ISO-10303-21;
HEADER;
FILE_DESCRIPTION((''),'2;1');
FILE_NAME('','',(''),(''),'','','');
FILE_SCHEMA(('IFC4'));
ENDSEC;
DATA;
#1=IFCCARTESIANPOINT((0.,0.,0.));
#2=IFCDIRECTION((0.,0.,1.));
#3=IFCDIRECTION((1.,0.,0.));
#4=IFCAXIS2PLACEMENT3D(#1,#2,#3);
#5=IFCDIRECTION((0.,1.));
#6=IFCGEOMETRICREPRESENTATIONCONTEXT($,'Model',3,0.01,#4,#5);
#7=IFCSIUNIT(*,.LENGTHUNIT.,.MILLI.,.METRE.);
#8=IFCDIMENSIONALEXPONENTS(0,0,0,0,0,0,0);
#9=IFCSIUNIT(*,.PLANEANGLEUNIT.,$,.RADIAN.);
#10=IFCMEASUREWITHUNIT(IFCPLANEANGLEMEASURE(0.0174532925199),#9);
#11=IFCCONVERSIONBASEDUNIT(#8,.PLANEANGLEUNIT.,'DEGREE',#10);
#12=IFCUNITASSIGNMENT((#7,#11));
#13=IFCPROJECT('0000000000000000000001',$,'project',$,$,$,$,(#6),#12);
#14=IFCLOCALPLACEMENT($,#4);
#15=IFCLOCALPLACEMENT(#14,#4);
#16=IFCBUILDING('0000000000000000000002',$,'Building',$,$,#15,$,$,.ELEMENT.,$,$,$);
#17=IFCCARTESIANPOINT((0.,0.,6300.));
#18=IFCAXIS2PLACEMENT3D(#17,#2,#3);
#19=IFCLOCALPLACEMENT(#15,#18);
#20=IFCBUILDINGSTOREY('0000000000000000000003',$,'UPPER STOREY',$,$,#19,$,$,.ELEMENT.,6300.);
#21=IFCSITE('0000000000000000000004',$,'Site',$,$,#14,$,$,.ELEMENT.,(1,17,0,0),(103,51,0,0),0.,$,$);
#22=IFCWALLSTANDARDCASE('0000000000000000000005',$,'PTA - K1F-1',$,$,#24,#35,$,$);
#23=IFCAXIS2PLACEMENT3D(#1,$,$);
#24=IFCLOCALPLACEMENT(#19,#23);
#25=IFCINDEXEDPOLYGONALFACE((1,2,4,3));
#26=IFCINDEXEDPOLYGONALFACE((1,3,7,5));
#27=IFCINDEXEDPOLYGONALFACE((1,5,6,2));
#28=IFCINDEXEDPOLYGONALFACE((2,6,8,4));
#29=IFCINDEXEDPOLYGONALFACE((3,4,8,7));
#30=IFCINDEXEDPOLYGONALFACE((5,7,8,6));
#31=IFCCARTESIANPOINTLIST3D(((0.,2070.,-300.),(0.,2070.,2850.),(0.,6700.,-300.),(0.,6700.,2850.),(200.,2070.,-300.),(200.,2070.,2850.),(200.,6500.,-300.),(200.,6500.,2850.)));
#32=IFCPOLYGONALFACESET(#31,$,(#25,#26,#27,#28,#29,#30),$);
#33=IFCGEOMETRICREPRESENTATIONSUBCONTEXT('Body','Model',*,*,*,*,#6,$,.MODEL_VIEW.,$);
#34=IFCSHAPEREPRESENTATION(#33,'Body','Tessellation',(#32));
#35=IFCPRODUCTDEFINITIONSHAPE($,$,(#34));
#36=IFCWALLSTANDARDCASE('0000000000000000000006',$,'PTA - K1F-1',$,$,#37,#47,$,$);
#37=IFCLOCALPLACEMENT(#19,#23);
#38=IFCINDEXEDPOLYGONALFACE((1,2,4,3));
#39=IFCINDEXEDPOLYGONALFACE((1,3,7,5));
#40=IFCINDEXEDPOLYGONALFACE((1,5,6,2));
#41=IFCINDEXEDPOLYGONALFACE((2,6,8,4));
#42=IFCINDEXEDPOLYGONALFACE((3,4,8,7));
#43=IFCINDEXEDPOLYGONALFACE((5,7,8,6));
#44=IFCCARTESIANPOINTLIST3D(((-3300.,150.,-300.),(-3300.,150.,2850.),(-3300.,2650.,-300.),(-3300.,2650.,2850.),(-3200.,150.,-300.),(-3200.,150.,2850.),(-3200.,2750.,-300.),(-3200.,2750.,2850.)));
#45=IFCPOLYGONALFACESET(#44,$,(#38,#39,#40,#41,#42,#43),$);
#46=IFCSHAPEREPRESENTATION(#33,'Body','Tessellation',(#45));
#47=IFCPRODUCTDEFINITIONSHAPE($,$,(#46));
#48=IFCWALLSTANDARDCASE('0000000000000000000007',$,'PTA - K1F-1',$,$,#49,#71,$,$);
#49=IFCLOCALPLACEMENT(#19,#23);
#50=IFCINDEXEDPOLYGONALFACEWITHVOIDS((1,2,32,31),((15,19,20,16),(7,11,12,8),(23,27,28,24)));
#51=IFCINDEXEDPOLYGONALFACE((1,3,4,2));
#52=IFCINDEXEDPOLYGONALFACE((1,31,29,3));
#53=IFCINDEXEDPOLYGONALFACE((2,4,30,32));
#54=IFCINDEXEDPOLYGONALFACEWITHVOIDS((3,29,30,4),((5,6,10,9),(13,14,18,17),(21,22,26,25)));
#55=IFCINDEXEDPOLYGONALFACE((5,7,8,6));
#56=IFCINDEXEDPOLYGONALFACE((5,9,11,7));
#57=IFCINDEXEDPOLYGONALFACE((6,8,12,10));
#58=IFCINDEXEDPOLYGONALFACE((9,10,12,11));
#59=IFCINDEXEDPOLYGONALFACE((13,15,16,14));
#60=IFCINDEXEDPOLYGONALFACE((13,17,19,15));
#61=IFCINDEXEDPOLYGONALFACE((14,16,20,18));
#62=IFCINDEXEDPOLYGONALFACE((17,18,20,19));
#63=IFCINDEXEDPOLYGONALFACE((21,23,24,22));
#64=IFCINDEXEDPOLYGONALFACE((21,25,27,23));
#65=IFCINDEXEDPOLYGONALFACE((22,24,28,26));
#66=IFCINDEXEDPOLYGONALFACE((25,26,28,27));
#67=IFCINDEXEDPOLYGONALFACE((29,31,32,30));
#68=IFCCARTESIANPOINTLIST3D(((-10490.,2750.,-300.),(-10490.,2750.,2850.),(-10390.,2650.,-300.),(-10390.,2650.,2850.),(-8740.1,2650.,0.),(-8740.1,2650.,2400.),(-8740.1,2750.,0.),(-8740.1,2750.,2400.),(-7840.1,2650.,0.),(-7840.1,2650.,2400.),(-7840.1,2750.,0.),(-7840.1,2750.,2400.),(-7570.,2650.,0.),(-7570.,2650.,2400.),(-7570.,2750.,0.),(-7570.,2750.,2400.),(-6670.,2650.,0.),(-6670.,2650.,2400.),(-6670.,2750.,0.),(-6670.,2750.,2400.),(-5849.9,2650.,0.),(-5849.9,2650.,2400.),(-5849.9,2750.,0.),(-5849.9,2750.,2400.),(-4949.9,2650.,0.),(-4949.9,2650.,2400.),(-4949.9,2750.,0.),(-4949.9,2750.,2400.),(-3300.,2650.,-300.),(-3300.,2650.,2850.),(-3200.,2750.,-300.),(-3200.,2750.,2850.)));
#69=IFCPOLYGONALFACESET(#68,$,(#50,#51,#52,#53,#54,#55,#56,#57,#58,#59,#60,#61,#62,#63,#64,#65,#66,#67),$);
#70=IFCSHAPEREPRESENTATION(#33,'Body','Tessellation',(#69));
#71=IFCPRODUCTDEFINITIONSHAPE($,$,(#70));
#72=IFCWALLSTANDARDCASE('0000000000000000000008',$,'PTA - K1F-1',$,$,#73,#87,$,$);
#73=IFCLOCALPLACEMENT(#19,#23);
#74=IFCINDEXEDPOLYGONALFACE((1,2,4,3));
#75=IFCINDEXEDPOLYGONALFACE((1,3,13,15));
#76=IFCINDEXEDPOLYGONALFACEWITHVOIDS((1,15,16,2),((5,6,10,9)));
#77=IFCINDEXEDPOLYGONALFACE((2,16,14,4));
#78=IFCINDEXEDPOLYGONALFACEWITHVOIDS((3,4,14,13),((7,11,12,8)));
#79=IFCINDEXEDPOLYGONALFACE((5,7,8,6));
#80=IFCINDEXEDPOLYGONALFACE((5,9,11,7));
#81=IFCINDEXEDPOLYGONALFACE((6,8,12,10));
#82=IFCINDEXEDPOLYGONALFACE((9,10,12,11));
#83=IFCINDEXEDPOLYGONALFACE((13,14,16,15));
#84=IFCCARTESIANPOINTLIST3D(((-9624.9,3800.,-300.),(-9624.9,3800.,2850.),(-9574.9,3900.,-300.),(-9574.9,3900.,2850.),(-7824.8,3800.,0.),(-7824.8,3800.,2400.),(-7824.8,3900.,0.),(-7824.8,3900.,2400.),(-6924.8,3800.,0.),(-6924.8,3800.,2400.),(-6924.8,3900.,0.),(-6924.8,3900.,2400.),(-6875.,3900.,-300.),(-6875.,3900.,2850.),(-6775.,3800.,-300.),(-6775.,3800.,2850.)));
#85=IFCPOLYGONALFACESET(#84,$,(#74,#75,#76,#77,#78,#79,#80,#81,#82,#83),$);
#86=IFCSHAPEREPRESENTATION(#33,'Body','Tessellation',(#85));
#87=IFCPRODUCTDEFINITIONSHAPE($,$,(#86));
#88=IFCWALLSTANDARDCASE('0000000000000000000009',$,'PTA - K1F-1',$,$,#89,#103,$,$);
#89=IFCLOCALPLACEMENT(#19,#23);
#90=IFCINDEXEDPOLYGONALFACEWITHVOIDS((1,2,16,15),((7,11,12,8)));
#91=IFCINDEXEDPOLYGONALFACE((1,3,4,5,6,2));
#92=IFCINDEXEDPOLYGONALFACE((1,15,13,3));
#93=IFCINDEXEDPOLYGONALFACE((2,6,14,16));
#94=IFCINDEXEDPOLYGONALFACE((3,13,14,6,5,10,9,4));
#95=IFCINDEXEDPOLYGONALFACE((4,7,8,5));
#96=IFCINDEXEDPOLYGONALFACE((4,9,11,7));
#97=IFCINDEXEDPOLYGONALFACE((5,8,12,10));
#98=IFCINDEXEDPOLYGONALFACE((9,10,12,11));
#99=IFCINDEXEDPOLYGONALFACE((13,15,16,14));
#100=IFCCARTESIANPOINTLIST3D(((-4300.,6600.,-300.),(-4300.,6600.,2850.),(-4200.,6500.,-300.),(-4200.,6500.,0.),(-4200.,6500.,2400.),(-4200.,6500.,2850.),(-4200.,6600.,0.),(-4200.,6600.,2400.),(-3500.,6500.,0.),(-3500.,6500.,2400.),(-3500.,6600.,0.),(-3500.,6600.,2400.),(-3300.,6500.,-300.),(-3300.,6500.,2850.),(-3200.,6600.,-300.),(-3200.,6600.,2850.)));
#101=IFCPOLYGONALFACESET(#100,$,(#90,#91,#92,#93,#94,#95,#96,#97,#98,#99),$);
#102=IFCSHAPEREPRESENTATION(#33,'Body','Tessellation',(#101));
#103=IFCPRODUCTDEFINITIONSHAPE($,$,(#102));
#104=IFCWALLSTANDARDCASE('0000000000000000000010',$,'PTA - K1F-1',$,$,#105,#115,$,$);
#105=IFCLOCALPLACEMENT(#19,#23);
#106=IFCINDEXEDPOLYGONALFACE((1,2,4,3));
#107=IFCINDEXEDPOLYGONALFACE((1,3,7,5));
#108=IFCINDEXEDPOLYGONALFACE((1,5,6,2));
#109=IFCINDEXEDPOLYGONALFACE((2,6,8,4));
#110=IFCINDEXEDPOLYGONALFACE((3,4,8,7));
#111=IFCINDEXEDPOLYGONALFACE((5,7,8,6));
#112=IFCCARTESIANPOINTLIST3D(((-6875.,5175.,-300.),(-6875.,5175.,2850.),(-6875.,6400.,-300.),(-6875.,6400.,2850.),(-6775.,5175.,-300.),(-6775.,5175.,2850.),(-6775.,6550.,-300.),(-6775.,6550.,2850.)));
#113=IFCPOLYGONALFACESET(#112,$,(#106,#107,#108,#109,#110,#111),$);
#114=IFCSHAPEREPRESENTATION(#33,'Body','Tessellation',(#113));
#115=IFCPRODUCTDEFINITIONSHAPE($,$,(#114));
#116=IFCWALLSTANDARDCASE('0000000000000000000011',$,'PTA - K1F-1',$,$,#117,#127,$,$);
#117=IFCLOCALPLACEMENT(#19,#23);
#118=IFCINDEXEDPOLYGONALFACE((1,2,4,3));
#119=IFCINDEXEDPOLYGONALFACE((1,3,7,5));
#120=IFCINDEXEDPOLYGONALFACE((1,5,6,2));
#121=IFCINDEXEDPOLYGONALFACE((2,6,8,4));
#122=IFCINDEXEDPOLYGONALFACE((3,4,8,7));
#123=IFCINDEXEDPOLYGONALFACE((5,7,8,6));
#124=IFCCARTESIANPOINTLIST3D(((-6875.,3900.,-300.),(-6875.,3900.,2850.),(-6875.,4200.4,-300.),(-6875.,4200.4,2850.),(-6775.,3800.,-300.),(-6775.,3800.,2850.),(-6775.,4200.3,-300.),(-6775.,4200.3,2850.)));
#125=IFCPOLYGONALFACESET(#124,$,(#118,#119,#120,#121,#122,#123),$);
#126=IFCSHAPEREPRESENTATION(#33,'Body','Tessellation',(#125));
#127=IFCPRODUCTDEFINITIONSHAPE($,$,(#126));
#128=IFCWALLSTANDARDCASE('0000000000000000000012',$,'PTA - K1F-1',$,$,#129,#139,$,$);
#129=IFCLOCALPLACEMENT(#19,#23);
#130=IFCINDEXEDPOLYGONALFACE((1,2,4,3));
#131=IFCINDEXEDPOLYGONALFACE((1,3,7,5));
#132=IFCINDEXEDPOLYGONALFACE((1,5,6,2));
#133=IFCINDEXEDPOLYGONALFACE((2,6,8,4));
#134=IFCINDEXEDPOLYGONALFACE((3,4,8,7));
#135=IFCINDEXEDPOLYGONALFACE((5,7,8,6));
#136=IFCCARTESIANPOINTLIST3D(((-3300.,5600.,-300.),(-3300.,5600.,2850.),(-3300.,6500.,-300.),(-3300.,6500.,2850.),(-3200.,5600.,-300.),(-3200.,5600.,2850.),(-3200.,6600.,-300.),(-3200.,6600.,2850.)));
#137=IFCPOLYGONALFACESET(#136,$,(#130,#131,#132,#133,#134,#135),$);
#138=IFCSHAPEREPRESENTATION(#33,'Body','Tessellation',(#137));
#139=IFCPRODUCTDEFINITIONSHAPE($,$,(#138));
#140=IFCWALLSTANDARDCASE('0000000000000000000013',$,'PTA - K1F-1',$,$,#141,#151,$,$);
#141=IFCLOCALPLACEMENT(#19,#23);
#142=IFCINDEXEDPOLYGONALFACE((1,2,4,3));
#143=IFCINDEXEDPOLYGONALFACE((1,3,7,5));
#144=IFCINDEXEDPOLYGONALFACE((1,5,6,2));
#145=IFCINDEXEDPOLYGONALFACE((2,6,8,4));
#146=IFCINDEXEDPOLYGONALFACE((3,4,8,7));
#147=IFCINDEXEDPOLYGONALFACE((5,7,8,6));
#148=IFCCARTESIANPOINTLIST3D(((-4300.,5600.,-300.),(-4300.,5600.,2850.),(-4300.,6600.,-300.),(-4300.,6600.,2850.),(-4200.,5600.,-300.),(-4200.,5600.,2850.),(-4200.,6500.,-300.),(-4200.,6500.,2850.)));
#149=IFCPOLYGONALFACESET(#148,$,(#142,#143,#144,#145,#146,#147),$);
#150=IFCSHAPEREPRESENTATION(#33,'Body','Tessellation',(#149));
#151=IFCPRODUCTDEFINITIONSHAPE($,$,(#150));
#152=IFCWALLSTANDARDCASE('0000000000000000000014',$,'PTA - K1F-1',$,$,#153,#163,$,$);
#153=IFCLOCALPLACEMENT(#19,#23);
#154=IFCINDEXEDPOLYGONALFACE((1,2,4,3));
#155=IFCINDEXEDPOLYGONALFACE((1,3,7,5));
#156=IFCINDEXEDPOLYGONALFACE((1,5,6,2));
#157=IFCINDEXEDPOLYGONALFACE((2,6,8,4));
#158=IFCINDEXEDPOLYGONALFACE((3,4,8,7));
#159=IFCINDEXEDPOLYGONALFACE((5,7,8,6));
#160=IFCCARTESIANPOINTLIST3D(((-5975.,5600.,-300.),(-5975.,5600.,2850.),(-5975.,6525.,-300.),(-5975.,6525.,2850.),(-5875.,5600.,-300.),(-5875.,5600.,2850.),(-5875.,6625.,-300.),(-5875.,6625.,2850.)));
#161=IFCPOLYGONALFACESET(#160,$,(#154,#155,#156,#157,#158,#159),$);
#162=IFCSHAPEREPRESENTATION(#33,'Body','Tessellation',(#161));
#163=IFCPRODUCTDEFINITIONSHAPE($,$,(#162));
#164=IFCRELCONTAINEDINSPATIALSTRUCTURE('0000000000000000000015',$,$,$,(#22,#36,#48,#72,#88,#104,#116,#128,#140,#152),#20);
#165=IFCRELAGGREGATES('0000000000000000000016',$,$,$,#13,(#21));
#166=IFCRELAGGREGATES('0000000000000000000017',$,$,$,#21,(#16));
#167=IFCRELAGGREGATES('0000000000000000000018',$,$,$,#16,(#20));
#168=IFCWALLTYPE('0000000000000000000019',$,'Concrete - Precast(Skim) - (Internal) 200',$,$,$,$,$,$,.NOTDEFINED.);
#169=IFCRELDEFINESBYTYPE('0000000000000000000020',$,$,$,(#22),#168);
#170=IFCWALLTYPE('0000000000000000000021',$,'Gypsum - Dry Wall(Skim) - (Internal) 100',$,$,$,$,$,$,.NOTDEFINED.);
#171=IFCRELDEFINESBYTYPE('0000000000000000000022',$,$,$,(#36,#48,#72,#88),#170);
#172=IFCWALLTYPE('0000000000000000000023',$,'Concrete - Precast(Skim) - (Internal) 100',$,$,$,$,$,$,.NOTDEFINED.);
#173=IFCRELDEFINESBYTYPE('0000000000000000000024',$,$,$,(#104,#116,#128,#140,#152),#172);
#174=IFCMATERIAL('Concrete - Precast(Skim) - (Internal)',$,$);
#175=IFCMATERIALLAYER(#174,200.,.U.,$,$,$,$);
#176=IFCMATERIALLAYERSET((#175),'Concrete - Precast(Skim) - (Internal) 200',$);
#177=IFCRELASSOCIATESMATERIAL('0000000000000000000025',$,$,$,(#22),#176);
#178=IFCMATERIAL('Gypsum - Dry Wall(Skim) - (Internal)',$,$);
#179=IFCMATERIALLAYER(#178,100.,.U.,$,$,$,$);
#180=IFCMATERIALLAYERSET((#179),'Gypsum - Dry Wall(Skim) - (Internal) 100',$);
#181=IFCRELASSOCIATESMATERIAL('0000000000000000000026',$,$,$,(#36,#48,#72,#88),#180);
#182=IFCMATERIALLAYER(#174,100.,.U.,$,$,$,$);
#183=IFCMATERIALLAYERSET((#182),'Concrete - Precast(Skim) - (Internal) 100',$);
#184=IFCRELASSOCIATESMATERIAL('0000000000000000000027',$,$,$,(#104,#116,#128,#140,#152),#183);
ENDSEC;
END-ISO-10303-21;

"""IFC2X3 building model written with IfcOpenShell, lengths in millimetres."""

from ifc_helpers import new_model, entity, si_unit, converted_unit, direction, frame, origin_with_axes, origin_2d_with_axis, place, context, subcontext, project, spatial, polyline, rectangle, outline, extrude, material, layer, layer_set, layer_usage, type_object, element, save


model = new_model("IFC2X3")

# Units and contexts
model_context = context("Model", 3, precision=0.01, world=origin_with_axes(), true_north=direction((0.0, 1.0)))
body_context = subcontext(model_context, "Body", "Model", "MODEL_VIEW")
ifc_project = project(units=[si_unit("LENGTHUNIT", "METRE", prefix="MILLI"), converted_unit("PLANEANGLEUNIT", "DEGREE", entity("IfcPlaneAngleMeasure", 0.0174532925199), si_unit("PLANEANGLEUNIT", "RADIAN"), dimensions=[0, 0, 0, 0, 0, 0, 0])], contexts=[model_context])

# Site, building, storey
site_placement = place(None, origin_with_axes())
site = spatial("IfcSite", under=ifc_project, at=site_placement, Name="Site", CompositionType="ELEMENT", RefLatitude=(1, 17, 0, 0), RefLongitude=(103, 51, 0, 0), RefElevation=0.0)
building_placement = place(site_placement, origin_with_axes())
building = spatial("IfcBuilding", under=site, at=building_placement, Name="Building", CompositionType="ELEMENT")
storey_placement = place(building_placement, frame((0.0, 0.0, 6300.0), z_axis=(0.0, 0.0, 1.0), x_axis=(1.0, 0.0, 0.0)))
storey = spatial("IfcBuildingStorey", under=building, at=storey_placement, Name="UPPER STOREY", CompositionType="ELEMENT", Elevation=6300.0)

# Shared definitions
ifc_material_1 = material(Name="Concrete - Precast(Skim) - (Internal)")

# Walls
ifc_layer_1 = layer(ifc_material_1, 200.0, ventilated="UNKNOWN")
ifc_layer_set_1 = layer_set([ifc_layer_1], Name="Concrete - Precast(Skim) - (Internal) 200")
wall_type_1 = type_object("IfcWallType", Name="Concrete - Precast(Skim) - (Internal) 200", PredefinedType="NOTDEFINED")
ifc_layer_usage_1 = layer_usage(ifc_layer_set_1, "AXIS2", "NEGATIVE", 0.0)
wall_1_placement = place(storey_placement, frame((0.0, 2070.0, -300.0), z_axis=(0.0, 0.0, 1.0), x_axis=(-0.000002, 1.0, 0.0)))
element("IfcWallStandardCase", 1, at=wall_1_placement, inside=storey, type_object=wall_type_1, material=ifc_layer_usage_1, Name="PTA - K1F-1", context=body_context, shape_type="SweptSolid", body=[
    extrude(outline(polyline([(0.0, -200.0), (4430.0, -200.0), (4630.0, 0.0), (0.0, 0.0), (0.0, -200.0)])), origin_with_axes(), (0.0, 0.0, 1.0), 3150.0),
])
ifc_material_2 = material(Name="Gypsum - Dry Wall(Skim) - (Internal)")
ifc_layer_2 = layer(ifc_material_2, 100.0, ventilated="UNKNOWN")
ifc_layer_set_2 = layer_set([ifc_layer_2], Name="Gypsum - Dry Wall(Skim) - (Internal) 100")
ifc_layer_usage_2 = layer_usage(ifc_layer_set_2, "AXIS2", "POSITIVE", 0.0)
wall_type_2 = type_object("IfcWallType", Name="Gypsum - Dry Wall(Skim) - (Internal) 100", PredefinedType="NOTDEFINED")
wall_2_placement = place(storey_placement, frame((-3300.0, 2750.0, -300.0), z_axis=(0.0, 0.0, 1.0), x_axis=(0.0, -1.0, 0.0)))
element("IfcWallStandardCase", 2, at=wall_2_placement, inside=storey, type_object=wall_type_2, material=ifc_layer_usage_2, Name="PTA - K1F-1", context=body_context, shape_type="SweptSolid", body=[
    extrude(outline(polyline([(100.0, 0.0), (2600.0, 0.0), (2600.0, 100.0), (0.0, 100.0), (100.0, 0.0)])), origin_with_axes(), (0.0, 0.0, 1.0), 3150.0),
])

# Wall, openings
ifc_layer_usage_3 = layer_usage(ifc_layer_set_2, "AXIS2", "POSITIVE", 0.0)
wall_3_placement = place(storey_placement, frame((-3300.0, 2750.0, -300.0), z_axis=(0.0, 0.0, 1.0), x_axis=(-1.0, 0.0, 0.0)))
wall_3 = element("IfcWallStandardCase", 3, at=wall_3_placement, inside=storey, type_object=wall_type_2, material=ifc_layer_usage_3, Name="PTA - K1F-1", context=body_context, shape_type="SweptSolid", body=[
    extrude(outline(polyline([(-100.0, 0.0), (7190.0, 0.0), (7090.0, 100.0), (0.0, 100.0), (-100.0, 0.0)])), origin_with_axes(), (0.0, 0.0, 1.0), 3150.0),
])
opening_1_placement = place(wall_3_placement, frame((2099.9, 0.0, 300.0), z_axis=(0.0, 0.0, 1.0), x_axis=(1.0, 0.0, 0.0)))
element("IfcOpeningElement", 4, at=opening_1_placement, cuts=wall_3, context=body_context, shape_type="SweptSolid", body=[
    extrude(rectangle(XDim=900.0, YDim=2400.0, at=origin_2d_with_axis()), frame((0.0, -100.0, 1200.0), z_axis=(0.0, 1.0, 0.0), x_axis=(1.0, 0.0, 0.0)), (0.0, 0.0, 1.0), 300.0),
])
opening_2_placement = place(wall_3_placement, frame((4990.1, 0.0, 300.0), z_axis=(0.0, 0.0, 1.0), x_axis=(1.0, 0.0, 0.0)))
element("IfcOpeningElement", 5, at=opening_2_placement, cuts=wall_3, context=body_context, shape_type="SweptSolid", body=[
    extrude(rectangle(XDim=900.0, YDim=2400.0, at=origin_2d_with_axis()), frame((0.0, -100.0, 1200.0), z_axis=(0.0, -1.0, 0.0), x_axis=(-1.0, 0.0, 0.0)), (0.0, 0.0, -1.0), 300.0),
])
opening_3_placement = place(wall_3_placement, frame((3820.0, 0.0, 300.0), z_axis=(0.0, 0.0, 1.0), x_axis=(1.0, 0.0, 0.0)))
element("IfcOpeningElement", 6, at=opening_3_placement, cuts=wall_3, context=body_context, shape_type="SweptSolid", body=[
    extrude(rectangle(XDim=900.0, YDim=2400.0, at=origin_2d_with_axis()), frame((0.0, 100.0, 1200.0), z_axis=(0.0, -1.0, 0.0), x_axis=(1.0, 0.0, 0.0)), (0.0, 0.0, 1.0), 300.0),
])

# Walls, openings
ifc_layer_usage_4 = layer_usage(ifc_layer_set_2, "AXIS2", "NEGATIVE", 0.0)
wall_4_placement = place(storey_placement, frame((-6875.0, 3800.0, -300.0), z_axis=(0.0, 0.0, 1.0), x_axis=(-1.0, 0.0, 0.0)))
wall_4 = element("IfcWallStandardCase", 7, at=wall_4_placement, inside=storey, type_object=wall_type_2, material=ifc_layer_usage_4, Name="PTA - K1F-1", context=body_context, shape_type="SweptSolid", body=[
    extrude(outline(polyline([(0.0, -100.0), (2699.9, -100.0), (2749.9, 0.0), (-100.0, 0.0), (0.0, -100.0)])), origin_with_axes(), (0.0, 0.0, 1.0), 3150.0),
])
opening_4_placement = place(wall_4_placement, frame((499.8, 0.0, 300.0), z_axis=(0.0, 0.0, 1.0), x_axis=(1.0, 0.0, 0.0)))
element("IfcOpeningElement", 8, at=opening_4_placement, cuts=wall_4, context=body_context, shape_type="SweptSolid", body=[
    extrude(rectangle(XDim=900.0, YDim=2400.0, at=origin_2d_with_axis()), frame((0.0, 100.0, 1200.0), z_axis=(0.0, -1.0, 0.0), x_axis=(-1.0, 0.0, 0.0)), (0.0, 0.0, 1.0), 300.0),
])
ifc_layer_usage_5 = layer_usage(ifc_layer_set_2, "AXIS2", "NEGATIVE", 0.0)
wall_5_placement = place(storey_placement, frame((-4300.0, 6600.0, -300.0), z_axis=(0.0, 0.0, 1.0), x_axis=(1.0, 0.0, 0.0)))
wall_5 = element("IfcWallStandardCase", 9, at=wall_5_placement, inside=storey, type_object=wall_type_2, material=ifc_layer_usage_5, Name="PTA - K1F-1", context=body_context, shape_type="SweptSolid", body=[
    extrude(outline(polyline([(100.0, -100.0), (1000.0, -100.0), (1100.0, 0.0), (0.0, 0.0), (100.0, -100.0)])), origin_with_axes(), (0.0, 0.0, 1.0), 3150.0),
])
opening_5_placement = place(wall_5_placement, frame((450.0, 0.0, 300.0), z_axis=(0.0, 0.0, 1.0), x_axis=(1.0, 0.0, 0.0)))
element("IfcOpeningElement", 10, at=opening_5_placement, cuts=wall_5, context=body_context, shape_type="SweptSolid", body=[
    extrude(rectangle(XDim=700.0, YDim=2400.0, at=origin_2d_with_axis()), frame((0.0, -100.0, 1200.0), z_axis=(0.0, 1.0, 0.0), x_axis=(1.0, 0.0, 0.0)), (0.0, 0.0, 1.0), 300.0),
])

# Walls
ifc_layer_3 = layer(ifc_material_1, 100.0, ventilated="UNKNOWN")
ifc_layer_set_3 = layer_set([ifc_layer_3], Name="Concrete - Precast(Skim) - (Internal) 100")
ifc_layer_usage_6 = layer_usage(ifc_layer_set_3, "AXIS2", "NEGATIVE", 0.0)
wall_type_3 = type_object("IfcWallType", Name="Concrete - Precast(Skim) - (Internal) 100", PredefinedType="NOTDEFINED")
wall_6_placement = place(storey_placement, frame((-6875.0, 5175.0, -300.0), z_axis=(0.0, 0.0, 1.0), x_axis=(0.0, 1.0, 0.0)))
element("IfcWallStandardCase", 11, at=wall_6_placement, inside=storey, type_object=wall_type_3, material=ifc_layer_usage_6, Name="PTA - K1F-1", context=body_context, shape_type="SweptSolid", body=[
    extrude(outline(polyline([(0.0, -100.0), (1375.0, -100.0), (1225.0, 0.0), (0.0, 0.0), (0.0, -100.0)])), origin_with_axes(), (0.0, 0.0, 1.0), 3150.0),
])
ifc_layer_usage_7 = layer_usage(ifc_layer_set_3, "AXIS2", "NEGATIVE", 0.0)
wall_7_placement = place(storey_placement, frame((-6875.0, 3800.0, -300.0), z_axis=(0.0, 0.0, 1.0), x_axis=(0.0, 1.0, 0.0)))
element("IfcWallStandardCase", 12, at=wall_7_placement, inside=storey, type_object=wall_type_3, material=ifc_layer_usage_7, Name="PTA - K1F-1", context=body_context, shape_type="SweptSolid", body=[
    extrude(outline(polyline([(0.0, -100.0), (400.3, -100.0), (400.4, 0.0), (100.0, 0.0), (0.0, -100.0)])), origin_with_axes(), (0.0, 0.0, 1.0), 3150.0),
])
ifc_layer_usage_8 = layer_usage(ifc_layer_set_3, "AXIS2", "POSITIVE", 0.0)
wall_8_placement = place(storey_placement, frame((-3200.0, 5600.0, -300.0), z_axis=(0.0, 0.0, 1.0), x_axis=(-0.000002, 1.0, 0.0)))
element("IfcWallStandardCase", 13, at=wall_8_placement, inside=storey, type_object=wall_type_3, material=ifc_layer_usage_8, Name="PTA - K1F-1", context=body_context, shape_type="SweptSolid", body=[
    extrude(outline(polyline([(0.0, 0.0), (1000.0, 0.0), (900.0, 100.0), (0.0, 100.0), (0.0, 0.0)])), origin_with_axes(), (0.0, 0.0, 1.0), 3150.0),
])
ifc_layer_usage_9 = layer_usage(ifc_layer_set_3, "AXIS2", "NEGATIVE", 0.0)
wall_9_placement = place(storey_placement, frame((-4300.0, 5600.0, -300.0), z_axis=(0.0, 0.0, 1.0), x_axis=(0.0, 1.0, 0.0)))
element("IfcWallStandardCase", 14, at=wall_9_placement, inside=storey, type_object=wall_type_3, material=ifc_layer_usage_9, Name="PTA - K1F-1", context=body_context, shape_type="SweptSolid", body=[
    extrude(outline(polyline([(0.0, -100.0), (900.0, -100.0), (1000.0, 0.0), (0.0, 0.0), (0.0, -100.0)])), origin_with_axes(), (0.0, 0.0, 1.0), 3150.0),
])
ifc_layer_usage_10 = layer_usage(ifc_layer_set_3, "AXIS2", "POSITIVE", 0.0)
wall_10_placement = place(storey_placement, frame((-5875.0, 5600.0, -300.0), z_axis=(0.0, 0.0, 1.0), x_axis=(0.0, 1.0, 0.0)))
element("IfcWallStandardCase", 15, at=wall_10_placement, inside=storey, type_object=wall_type_3, material=ifc_layer_usage_10, Name="PTA - K1F-1", context=body_context, shape_type="SweptSolid", body=[
    extrude(outline(polyline([(0.0, 0.0), (1025.1, 0.0), (925.1, 100.0), (0.0, 100.0), (0.0, 0.0)])), origin_with_axes(), (0.0, 0.0, 1.0), 3150.0),
])

save(model, "model.ifc")
